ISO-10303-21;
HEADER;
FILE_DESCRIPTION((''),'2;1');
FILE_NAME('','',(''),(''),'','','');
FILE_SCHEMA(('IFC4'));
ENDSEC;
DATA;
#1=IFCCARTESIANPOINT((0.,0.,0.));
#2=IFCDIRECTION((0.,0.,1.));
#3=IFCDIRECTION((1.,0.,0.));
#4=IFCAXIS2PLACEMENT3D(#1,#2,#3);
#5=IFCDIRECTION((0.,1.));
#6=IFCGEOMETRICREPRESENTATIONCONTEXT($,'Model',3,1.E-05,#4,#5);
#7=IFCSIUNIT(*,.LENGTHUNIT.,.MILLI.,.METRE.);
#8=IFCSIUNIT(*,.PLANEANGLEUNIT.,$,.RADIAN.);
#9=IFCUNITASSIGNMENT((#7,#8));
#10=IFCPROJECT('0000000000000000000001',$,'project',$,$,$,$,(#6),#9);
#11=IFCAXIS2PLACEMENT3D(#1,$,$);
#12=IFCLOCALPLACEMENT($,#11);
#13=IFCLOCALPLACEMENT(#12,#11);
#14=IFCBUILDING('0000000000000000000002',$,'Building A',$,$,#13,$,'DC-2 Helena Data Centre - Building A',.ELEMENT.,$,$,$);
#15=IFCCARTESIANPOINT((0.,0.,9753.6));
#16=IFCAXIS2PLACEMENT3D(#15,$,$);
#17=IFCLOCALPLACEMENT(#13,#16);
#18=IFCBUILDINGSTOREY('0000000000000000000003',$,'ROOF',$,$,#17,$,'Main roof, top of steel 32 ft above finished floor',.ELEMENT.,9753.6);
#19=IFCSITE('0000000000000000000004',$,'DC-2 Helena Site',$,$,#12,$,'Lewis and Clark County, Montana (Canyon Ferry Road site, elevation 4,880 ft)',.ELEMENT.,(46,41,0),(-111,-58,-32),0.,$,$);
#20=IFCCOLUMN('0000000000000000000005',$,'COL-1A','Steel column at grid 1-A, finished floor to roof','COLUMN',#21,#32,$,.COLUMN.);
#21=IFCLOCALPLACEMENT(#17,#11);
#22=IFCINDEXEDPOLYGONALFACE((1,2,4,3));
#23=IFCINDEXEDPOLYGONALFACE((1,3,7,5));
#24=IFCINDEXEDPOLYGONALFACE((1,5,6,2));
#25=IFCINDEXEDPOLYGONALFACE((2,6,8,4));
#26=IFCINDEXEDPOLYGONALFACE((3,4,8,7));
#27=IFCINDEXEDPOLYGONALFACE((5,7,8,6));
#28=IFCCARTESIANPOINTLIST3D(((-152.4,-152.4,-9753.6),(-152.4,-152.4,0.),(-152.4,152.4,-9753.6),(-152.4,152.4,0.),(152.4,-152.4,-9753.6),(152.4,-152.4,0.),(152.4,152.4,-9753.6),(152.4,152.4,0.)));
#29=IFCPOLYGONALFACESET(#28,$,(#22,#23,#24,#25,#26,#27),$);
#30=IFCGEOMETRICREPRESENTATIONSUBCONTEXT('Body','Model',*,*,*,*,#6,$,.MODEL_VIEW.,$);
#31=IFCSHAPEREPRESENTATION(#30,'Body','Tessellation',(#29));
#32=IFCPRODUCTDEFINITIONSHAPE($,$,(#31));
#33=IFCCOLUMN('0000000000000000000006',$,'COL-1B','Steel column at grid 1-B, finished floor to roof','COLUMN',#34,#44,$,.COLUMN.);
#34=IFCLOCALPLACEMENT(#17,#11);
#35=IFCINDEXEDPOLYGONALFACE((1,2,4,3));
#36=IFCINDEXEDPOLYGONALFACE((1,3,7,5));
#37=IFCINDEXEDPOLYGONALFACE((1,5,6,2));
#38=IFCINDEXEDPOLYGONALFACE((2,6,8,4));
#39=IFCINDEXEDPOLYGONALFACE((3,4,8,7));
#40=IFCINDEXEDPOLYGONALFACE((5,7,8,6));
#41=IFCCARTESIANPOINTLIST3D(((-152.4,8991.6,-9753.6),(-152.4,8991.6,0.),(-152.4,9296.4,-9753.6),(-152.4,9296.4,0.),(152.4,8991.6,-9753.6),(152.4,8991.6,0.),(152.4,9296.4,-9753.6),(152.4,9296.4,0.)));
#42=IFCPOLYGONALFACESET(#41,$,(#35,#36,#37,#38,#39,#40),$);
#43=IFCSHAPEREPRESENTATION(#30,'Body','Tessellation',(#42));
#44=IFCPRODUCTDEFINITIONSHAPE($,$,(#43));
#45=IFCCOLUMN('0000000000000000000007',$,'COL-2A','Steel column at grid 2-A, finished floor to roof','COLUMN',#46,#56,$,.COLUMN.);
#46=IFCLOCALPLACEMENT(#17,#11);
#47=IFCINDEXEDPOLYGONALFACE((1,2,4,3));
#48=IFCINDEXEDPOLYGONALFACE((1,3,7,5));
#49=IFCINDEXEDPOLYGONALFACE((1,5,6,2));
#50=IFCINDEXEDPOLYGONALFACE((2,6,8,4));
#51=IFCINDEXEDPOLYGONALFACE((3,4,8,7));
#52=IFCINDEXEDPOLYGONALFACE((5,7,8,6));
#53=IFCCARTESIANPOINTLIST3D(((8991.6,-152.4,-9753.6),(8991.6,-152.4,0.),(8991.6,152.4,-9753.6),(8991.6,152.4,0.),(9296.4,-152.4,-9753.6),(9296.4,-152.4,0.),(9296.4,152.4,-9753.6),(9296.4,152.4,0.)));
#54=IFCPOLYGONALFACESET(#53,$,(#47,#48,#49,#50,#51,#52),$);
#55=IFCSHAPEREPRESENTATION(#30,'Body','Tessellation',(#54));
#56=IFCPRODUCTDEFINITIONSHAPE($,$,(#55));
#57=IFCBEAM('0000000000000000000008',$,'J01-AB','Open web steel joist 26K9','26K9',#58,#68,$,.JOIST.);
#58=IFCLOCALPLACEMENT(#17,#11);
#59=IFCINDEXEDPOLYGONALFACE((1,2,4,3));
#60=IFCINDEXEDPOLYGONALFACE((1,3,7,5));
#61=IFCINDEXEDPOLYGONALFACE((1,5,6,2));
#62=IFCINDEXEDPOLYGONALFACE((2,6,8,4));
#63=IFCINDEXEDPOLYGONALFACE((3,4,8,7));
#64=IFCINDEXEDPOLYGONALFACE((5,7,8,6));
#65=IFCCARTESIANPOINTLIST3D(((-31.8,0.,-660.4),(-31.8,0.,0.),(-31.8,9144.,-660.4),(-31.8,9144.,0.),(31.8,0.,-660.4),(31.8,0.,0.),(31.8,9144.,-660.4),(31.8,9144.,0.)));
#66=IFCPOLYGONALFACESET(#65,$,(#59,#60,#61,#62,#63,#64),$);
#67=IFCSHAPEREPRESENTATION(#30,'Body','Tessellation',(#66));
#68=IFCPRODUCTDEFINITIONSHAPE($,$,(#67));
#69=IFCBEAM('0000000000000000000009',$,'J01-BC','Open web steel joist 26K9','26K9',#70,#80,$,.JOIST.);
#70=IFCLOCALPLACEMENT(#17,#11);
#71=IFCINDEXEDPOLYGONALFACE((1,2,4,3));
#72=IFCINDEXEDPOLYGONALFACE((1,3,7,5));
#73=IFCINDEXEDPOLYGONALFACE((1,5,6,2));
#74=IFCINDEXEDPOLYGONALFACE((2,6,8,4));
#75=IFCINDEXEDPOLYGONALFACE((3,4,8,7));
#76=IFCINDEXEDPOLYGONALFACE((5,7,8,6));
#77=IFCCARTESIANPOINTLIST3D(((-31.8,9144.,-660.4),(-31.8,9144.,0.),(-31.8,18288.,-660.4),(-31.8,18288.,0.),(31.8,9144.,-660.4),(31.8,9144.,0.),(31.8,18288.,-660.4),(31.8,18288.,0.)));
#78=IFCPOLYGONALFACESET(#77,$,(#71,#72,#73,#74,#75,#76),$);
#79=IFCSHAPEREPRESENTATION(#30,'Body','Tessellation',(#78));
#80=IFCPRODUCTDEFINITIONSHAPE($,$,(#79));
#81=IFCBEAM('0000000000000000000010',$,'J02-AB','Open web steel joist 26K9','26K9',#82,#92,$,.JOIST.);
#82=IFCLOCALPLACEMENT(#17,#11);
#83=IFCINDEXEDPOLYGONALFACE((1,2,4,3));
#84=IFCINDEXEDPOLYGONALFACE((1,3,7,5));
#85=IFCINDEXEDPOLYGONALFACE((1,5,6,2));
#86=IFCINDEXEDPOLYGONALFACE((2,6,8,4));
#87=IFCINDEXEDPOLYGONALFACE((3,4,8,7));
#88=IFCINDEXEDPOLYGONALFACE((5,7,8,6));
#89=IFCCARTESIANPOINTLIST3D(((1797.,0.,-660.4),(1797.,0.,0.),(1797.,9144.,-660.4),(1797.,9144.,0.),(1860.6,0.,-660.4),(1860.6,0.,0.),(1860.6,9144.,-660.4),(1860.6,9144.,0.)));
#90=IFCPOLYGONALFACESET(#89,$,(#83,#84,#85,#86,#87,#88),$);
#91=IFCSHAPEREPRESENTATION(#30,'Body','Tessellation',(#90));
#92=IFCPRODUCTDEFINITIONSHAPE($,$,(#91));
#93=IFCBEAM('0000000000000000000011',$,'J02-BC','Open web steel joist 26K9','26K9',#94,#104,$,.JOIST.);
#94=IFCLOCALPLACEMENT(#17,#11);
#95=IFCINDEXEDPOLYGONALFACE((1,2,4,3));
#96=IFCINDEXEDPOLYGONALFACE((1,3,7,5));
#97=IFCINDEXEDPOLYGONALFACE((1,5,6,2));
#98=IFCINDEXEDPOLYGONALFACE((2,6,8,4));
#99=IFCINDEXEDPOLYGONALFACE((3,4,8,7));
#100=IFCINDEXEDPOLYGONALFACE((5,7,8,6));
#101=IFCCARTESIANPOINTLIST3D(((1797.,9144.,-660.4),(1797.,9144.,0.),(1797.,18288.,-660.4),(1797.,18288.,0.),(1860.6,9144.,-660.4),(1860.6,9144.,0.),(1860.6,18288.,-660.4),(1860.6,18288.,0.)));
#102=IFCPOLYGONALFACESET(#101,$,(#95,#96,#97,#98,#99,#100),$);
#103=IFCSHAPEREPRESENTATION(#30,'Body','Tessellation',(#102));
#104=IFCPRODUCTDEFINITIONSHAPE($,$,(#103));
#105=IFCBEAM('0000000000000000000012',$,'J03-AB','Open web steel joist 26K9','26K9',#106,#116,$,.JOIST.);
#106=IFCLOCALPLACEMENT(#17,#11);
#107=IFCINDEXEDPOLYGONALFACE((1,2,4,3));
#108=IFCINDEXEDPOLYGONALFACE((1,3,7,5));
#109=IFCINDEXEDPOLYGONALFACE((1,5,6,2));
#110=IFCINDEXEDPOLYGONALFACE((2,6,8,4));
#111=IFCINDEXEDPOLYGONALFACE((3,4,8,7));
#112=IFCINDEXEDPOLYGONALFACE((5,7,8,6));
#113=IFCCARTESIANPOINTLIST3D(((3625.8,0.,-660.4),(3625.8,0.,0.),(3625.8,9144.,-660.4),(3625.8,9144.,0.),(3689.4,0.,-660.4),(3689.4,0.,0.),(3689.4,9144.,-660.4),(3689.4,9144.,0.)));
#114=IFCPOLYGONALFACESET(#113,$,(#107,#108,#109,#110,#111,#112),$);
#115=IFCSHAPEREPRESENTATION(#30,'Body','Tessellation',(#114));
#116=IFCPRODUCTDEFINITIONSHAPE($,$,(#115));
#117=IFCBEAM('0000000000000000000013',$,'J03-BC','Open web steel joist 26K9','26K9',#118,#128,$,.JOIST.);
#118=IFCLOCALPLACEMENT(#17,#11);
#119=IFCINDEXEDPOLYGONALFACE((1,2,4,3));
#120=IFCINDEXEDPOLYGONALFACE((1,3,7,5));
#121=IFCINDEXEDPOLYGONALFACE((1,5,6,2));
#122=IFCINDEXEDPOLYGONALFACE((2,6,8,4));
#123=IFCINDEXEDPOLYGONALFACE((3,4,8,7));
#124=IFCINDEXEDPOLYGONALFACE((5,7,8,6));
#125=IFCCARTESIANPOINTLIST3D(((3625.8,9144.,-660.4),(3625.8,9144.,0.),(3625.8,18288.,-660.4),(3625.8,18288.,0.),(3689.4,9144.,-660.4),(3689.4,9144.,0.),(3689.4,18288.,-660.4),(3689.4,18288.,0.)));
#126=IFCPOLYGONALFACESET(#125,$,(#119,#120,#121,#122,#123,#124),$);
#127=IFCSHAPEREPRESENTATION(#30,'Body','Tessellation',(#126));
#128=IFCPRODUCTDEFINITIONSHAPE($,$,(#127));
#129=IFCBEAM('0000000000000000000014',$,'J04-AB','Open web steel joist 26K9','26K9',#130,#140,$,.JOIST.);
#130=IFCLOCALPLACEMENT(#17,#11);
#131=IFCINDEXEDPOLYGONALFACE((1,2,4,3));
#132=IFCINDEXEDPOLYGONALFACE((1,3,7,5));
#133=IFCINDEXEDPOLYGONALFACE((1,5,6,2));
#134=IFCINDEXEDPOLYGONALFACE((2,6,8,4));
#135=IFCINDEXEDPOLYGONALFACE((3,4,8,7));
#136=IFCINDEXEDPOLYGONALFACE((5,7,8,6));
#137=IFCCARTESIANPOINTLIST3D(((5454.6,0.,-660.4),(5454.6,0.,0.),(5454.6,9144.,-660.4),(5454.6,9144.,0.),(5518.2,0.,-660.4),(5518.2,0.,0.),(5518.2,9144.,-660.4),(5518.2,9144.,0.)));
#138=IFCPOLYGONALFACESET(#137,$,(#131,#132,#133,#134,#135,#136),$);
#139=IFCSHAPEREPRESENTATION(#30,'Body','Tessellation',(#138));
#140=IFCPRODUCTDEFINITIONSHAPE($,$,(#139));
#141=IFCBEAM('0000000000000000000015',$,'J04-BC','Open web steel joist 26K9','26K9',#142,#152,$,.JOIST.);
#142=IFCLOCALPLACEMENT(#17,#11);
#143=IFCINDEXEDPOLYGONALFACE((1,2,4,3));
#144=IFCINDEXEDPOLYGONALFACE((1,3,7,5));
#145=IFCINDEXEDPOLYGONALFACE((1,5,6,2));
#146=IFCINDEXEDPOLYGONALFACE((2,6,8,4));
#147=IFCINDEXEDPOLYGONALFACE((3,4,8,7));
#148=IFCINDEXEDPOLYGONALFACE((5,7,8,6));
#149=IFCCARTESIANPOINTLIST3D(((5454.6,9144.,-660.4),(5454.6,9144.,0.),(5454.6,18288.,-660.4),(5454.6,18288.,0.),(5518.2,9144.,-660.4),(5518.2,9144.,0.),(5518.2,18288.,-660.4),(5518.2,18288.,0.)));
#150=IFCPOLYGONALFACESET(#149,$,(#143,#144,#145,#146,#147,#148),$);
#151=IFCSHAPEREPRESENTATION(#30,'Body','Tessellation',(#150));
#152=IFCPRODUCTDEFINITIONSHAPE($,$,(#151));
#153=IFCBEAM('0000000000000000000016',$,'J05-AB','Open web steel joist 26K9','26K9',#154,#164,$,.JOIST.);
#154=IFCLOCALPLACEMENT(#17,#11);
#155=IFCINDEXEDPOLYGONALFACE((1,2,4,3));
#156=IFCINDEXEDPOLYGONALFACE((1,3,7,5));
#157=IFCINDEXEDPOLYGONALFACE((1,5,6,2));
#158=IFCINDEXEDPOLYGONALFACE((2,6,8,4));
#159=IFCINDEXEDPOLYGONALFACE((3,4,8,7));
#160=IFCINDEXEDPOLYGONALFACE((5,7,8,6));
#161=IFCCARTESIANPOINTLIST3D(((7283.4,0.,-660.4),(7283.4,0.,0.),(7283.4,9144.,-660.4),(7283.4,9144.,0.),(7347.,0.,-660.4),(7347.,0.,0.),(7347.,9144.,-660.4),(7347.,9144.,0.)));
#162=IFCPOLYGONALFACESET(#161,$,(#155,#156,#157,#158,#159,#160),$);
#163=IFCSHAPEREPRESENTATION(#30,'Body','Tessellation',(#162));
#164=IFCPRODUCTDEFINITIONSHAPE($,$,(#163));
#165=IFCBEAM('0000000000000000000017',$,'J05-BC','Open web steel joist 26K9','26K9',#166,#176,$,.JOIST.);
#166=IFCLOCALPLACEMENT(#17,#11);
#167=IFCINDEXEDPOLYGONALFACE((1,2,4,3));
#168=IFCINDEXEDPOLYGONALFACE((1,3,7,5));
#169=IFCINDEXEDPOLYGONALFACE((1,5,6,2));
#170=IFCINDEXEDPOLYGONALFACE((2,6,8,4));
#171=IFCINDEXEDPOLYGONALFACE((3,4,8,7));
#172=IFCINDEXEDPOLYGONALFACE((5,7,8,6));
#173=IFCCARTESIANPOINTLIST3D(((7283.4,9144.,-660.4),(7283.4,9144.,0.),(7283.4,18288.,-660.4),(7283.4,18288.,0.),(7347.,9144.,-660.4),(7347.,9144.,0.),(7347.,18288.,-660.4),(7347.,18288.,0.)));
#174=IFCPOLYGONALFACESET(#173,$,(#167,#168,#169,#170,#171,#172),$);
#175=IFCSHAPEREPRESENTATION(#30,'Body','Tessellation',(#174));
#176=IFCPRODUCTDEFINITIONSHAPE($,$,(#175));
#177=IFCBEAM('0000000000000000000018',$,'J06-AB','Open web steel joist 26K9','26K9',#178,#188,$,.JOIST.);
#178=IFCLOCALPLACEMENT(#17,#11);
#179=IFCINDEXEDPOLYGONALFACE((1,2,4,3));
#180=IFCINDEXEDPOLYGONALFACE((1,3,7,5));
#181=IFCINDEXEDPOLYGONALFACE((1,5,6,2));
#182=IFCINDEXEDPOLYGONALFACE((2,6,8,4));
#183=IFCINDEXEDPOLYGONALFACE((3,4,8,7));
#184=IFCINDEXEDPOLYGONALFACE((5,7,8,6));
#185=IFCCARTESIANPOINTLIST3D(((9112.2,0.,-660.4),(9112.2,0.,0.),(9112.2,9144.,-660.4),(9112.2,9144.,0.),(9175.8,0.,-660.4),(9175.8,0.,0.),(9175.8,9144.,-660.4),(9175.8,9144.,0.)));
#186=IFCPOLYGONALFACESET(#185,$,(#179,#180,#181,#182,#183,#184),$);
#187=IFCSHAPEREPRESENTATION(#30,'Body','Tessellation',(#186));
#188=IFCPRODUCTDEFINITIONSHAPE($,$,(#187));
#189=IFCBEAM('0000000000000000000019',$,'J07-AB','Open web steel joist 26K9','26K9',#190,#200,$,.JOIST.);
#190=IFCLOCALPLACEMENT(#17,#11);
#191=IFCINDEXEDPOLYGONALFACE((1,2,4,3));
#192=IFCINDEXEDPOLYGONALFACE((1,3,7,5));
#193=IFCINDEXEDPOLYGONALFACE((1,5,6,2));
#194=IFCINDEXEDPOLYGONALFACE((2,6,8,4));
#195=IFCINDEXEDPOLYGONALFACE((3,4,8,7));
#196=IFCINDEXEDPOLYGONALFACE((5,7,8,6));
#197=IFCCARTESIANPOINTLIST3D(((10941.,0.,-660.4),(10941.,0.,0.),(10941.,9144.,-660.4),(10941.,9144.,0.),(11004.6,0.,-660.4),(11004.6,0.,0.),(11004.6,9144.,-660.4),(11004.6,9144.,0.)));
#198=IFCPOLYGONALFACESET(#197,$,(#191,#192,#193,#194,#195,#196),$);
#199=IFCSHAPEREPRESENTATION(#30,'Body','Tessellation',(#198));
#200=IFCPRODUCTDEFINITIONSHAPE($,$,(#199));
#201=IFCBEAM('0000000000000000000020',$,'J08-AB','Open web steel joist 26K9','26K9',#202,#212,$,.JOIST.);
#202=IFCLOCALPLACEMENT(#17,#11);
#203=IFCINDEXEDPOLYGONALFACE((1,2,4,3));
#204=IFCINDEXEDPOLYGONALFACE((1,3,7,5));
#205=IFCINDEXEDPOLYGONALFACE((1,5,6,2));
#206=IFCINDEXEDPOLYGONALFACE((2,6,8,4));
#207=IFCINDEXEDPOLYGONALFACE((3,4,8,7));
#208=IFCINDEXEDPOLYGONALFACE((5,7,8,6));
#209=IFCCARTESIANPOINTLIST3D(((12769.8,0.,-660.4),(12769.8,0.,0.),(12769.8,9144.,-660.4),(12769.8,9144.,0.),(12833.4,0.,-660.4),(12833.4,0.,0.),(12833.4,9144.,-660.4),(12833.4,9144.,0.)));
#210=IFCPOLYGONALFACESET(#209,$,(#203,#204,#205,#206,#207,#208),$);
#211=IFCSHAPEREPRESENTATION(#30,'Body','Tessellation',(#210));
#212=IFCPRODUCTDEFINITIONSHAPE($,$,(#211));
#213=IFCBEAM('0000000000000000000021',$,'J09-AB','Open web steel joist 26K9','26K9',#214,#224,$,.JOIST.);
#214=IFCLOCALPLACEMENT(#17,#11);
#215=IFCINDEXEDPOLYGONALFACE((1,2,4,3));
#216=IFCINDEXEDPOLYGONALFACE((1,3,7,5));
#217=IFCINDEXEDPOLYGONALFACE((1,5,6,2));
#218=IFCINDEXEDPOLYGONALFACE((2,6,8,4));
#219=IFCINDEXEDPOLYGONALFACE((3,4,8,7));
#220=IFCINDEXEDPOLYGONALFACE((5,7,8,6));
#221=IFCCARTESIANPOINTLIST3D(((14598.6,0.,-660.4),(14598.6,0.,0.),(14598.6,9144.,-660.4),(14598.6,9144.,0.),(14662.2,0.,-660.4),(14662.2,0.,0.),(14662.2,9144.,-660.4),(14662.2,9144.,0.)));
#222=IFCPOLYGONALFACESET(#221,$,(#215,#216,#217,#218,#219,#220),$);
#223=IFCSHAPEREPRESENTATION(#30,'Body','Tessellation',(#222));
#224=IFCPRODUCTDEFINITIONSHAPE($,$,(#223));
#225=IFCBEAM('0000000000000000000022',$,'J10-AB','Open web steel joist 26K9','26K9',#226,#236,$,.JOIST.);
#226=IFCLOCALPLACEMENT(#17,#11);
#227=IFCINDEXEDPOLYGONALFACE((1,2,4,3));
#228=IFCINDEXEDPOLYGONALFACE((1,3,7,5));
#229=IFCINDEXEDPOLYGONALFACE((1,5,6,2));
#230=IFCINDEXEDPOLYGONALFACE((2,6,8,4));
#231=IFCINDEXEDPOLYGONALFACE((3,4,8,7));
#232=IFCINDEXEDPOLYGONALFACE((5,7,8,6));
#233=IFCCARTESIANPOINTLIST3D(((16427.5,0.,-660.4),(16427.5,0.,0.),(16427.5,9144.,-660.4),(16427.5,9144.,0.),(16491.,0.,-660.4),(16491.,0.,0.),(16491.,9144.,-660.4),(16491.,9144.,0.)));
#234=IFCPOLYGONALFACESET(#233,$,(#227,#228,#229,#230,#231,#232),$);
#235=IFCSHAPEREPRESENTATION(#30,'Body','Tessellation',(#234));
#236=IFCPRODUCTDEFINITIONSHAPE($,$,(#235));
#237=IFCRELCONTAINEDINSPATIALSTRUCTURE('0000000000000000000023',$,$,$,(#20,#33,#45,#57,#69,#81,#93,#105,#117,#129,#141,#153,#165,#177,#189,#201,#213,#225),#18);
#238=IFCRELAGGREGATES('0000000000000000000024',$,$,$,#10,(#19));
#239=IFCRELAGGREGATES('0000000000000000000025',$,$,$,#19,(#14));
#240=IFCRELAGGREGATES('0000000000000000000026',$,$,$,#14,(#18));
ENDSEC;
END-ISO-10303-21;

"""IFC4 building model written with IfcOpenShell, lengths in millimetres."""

from ifc_helpers import new_model, si_unit, direction, frame, origin, origin_with_axes, origin_2d, place, context, subcontext, project, spatial, rectangle, extrude, element, save


model = new_model("IFC4")

# Units and contexts
model_context = context("Model", 3, precision=1e-05, world=origin_with_axes(), true_north=direction((0.0, 1.0)))
body_context = subcontext(model_context, "Body", "Model", "MODEL_VIEW")
ifc_project = project(units=[si_unit("LENGTHUNIT", "METRE", prefix="MILLI"), si_unit("PLANEANGLEUNIT", "RADIAN")], contexts=[model_context])

# Site, building, storey
site_placement = place(None, origin())
site = spatial("IfcSite", under=ifc_project, at=site_placement, Name="DC-2 Helena Site", LongName="Lewis and Clark County, Montana (Canyon Ferry Road site, elevation 4,880 ft)", CompositionType="ELEMENT", RefLatitude=(46, 41, 0), RefLongitude=(-111, -58, -32), RefElevation=0.0)
building_placement = place(site_placement, origin())
building = spatial("IfcBuilding", under=site, at=building_placement, Name="Building A", LongName="DC-2 Helena Data Centre - Building A", CompositionType="ELEMENT")
storey_placement = place(building_placement, frame((0.0, 0.0, 9753.6)))
storey = spatial("IfcBuildingStorey", under=building, at=storey_placement, Name="ROOF", LongName="Main roof, top of steel 32 ft above finished floor", CompositionType="ELEMENT", Elevation=9753.6)

# Columns
column_1_placement = place(storey_placement, frame((0.0, 0.0, -9753.6)))
element("IfcColumn", 1, at=column_1_placement, inside=storey, Name="COL-1A", Description="Steel column at grid 1-A, finished floor to roof", ObjectType="COLUMN", PredefinedType="COLUMN", context=body_context, shape_type="SweptSolid", body=[
    extrude(rectangle(XDim=304.8, YDim=304.8, at=origin_2d()), origin(), (0.0, 0.0, 1.0), 9753.6),
])
placement_1 = place(storey_placement, frame((0.0, 9144.0, -9753.6)))
element("IfcColumn", 2, at=placement_1, inside=storey, Name="COL-1B", Description="Steel column at grid 1-B, finished floor to roof", ObjectType="COLUMN", PredefinedType="COLUMN", context=body_context, shape_type="SweptSolid", body=[
    extrude(rectangle(XDim=304.8, YDim=304.8, at=origin_2d()), origin(), (0.0, 0.0, 1.0), 9753.6),
])
placement_2 = place(storey_placement, frame((9144.0, 0.0, -9753.6)))
element("IfcColumn", 3, at=placement_2, inside=storey, Name="COL-2A", Description="Steel column at grid 2-A, finished floor to roof", ObjectType="COLUMN", PredefinedType="COLUMN", context=body_context, shape_type="SweptSolid", body=[
    extrude(rectangle(XDim=304.8, YDim=304.8, at=origin_2d()), origin(), (0.0, 0.0, 1.0), 9753.6),
])

# Beams
placement_3 = place(storey_placement, origin())
element("IfcBeam", 4, at=placement_3, inside=storey, Name="J01-AB", Description="Open web steel joist 26K9", ObjectType="26K9", PredefinedType="JOIST", context=body_context, shape_type="SweptSolid", body=[
    extrude(rectangle(XDim=63.5, YDim=660.4, at=origin_2d()), frame((0.0, 0.0, -330.2), z_axis=(0.0, 1.0, 0.0), x_axis=(1.0, 0.0, 0.0)), (0.0, 0.0, 1.0), 9144.0),
])
placement_4 = place(storey_placement, frame((0.0, 9144.0, 0.0)))
element("IfcBeam", 5, at=placement_4, inside=storey, Name="J01-BC", Description="Open web steel joist 26K9", ObjectType="26K9", PredefinedType="JOIST", context=body_context, shape_type="SweptSolid", body=[
    extrude(rectangle(XDim=63.5, YDim=660.4, at=origin_2d()), frame((0.0, 0.0, -330.2), z_axis=(0.0, 1.0, 0.0), x_axis=(1.0, 0.0, 0.0)), (0.0, 0.0, 1.0), 9144.0),
])
for number, where, name in (
    (6, (1828.8, 0.0, 0.0), "J02-AB"),
    (7, (1828.8, 9144.0, 0.0), "J02-BC"),
    (8, (3657.6, 0.0, 0.0), "J03-AB"),
    (9, (3657.6, 9144.0, 0.0), "J03-BC"),
    (10, (5486.4, 0.0, 0.0), "J04-AB"),
    (11, (5486.4, 9144.0, 0.0), "J04-BC"),
    (12, (7315.2, 0.0, 0.0), "J05-AB"),
    (13, (7315.2, 9144.0, 0.0), "J05-BC"),
):
    element("IfcBeam", number, at=place(storey_placement, frame(where)), inside=storey, Name=name, Description="Open web steel joist 26K9", ObjectType="26K9", PredefinedType="JOIST", context=body_context, shape_type="SweptSolid", body=[
        extrude(rectangle(XDim=63.5, YDim=660.4, at=origin_2d()), frame((0.0, 0.0, -330.2), z_axis=(0.0, 1.0, 0.0), x_axis=(1.0, 0.0, 0.0)), (0.0, 0.0, 1.0), 9144.0),
    ])
placement_5 = place(storey_placement, frame((9144.0, 0.0, 0.0)))
element("IfcBeam", 14, at=placement_5, inside=storey, Name="J06-AB", Description="Open web steel joist 26K9", ObjectType="26K9", PredefinedType="JOIST", context=body_context, shape_type="SweptSolid", body=[
    extrude(rectangle(XDim=63.5, YDim=660.4, at=origin_2d()), frame((0.0, 0.0, -330.2), z_axis=(0.0, 1.0, 0.0), x_axis=(1.0, 0.0, 0.0)), (0.0, 0.0, 1.0), 9144.0),
])
for number, where, name in (
    (15, (10972.8, 0.0, 0.0), "J07-AB"),
    (16, (12801.6, 0.0, 0.0), "J08-AB"),
    (17, (14630.4, 0.0, 0.0), "J09-AB"),
    (18, (16459.2, 0.0, 0.0), "J10-AB"),
):
    element("IfcBeam", number, at=place(storey_placement, frame(where)), inside=storey, Name=name, Description="Open web steel joist 26K9", ObjectType="26K9", PredefinedType="JOIST", context=body_context, shape_type="SweptSolid", body=[
        extrude(rectangle(XDim=63.5, YDim=660.4, at=origin_2d()), frame((0.0, 0.0, -330.2), z_axis=(0.0, 1.0, 0.0), x_axis=(1.0, 0.0, 0.0)), (0.0, 0.0, 1.0), 9144.0),
    ])

save(model, "model.ifc")
